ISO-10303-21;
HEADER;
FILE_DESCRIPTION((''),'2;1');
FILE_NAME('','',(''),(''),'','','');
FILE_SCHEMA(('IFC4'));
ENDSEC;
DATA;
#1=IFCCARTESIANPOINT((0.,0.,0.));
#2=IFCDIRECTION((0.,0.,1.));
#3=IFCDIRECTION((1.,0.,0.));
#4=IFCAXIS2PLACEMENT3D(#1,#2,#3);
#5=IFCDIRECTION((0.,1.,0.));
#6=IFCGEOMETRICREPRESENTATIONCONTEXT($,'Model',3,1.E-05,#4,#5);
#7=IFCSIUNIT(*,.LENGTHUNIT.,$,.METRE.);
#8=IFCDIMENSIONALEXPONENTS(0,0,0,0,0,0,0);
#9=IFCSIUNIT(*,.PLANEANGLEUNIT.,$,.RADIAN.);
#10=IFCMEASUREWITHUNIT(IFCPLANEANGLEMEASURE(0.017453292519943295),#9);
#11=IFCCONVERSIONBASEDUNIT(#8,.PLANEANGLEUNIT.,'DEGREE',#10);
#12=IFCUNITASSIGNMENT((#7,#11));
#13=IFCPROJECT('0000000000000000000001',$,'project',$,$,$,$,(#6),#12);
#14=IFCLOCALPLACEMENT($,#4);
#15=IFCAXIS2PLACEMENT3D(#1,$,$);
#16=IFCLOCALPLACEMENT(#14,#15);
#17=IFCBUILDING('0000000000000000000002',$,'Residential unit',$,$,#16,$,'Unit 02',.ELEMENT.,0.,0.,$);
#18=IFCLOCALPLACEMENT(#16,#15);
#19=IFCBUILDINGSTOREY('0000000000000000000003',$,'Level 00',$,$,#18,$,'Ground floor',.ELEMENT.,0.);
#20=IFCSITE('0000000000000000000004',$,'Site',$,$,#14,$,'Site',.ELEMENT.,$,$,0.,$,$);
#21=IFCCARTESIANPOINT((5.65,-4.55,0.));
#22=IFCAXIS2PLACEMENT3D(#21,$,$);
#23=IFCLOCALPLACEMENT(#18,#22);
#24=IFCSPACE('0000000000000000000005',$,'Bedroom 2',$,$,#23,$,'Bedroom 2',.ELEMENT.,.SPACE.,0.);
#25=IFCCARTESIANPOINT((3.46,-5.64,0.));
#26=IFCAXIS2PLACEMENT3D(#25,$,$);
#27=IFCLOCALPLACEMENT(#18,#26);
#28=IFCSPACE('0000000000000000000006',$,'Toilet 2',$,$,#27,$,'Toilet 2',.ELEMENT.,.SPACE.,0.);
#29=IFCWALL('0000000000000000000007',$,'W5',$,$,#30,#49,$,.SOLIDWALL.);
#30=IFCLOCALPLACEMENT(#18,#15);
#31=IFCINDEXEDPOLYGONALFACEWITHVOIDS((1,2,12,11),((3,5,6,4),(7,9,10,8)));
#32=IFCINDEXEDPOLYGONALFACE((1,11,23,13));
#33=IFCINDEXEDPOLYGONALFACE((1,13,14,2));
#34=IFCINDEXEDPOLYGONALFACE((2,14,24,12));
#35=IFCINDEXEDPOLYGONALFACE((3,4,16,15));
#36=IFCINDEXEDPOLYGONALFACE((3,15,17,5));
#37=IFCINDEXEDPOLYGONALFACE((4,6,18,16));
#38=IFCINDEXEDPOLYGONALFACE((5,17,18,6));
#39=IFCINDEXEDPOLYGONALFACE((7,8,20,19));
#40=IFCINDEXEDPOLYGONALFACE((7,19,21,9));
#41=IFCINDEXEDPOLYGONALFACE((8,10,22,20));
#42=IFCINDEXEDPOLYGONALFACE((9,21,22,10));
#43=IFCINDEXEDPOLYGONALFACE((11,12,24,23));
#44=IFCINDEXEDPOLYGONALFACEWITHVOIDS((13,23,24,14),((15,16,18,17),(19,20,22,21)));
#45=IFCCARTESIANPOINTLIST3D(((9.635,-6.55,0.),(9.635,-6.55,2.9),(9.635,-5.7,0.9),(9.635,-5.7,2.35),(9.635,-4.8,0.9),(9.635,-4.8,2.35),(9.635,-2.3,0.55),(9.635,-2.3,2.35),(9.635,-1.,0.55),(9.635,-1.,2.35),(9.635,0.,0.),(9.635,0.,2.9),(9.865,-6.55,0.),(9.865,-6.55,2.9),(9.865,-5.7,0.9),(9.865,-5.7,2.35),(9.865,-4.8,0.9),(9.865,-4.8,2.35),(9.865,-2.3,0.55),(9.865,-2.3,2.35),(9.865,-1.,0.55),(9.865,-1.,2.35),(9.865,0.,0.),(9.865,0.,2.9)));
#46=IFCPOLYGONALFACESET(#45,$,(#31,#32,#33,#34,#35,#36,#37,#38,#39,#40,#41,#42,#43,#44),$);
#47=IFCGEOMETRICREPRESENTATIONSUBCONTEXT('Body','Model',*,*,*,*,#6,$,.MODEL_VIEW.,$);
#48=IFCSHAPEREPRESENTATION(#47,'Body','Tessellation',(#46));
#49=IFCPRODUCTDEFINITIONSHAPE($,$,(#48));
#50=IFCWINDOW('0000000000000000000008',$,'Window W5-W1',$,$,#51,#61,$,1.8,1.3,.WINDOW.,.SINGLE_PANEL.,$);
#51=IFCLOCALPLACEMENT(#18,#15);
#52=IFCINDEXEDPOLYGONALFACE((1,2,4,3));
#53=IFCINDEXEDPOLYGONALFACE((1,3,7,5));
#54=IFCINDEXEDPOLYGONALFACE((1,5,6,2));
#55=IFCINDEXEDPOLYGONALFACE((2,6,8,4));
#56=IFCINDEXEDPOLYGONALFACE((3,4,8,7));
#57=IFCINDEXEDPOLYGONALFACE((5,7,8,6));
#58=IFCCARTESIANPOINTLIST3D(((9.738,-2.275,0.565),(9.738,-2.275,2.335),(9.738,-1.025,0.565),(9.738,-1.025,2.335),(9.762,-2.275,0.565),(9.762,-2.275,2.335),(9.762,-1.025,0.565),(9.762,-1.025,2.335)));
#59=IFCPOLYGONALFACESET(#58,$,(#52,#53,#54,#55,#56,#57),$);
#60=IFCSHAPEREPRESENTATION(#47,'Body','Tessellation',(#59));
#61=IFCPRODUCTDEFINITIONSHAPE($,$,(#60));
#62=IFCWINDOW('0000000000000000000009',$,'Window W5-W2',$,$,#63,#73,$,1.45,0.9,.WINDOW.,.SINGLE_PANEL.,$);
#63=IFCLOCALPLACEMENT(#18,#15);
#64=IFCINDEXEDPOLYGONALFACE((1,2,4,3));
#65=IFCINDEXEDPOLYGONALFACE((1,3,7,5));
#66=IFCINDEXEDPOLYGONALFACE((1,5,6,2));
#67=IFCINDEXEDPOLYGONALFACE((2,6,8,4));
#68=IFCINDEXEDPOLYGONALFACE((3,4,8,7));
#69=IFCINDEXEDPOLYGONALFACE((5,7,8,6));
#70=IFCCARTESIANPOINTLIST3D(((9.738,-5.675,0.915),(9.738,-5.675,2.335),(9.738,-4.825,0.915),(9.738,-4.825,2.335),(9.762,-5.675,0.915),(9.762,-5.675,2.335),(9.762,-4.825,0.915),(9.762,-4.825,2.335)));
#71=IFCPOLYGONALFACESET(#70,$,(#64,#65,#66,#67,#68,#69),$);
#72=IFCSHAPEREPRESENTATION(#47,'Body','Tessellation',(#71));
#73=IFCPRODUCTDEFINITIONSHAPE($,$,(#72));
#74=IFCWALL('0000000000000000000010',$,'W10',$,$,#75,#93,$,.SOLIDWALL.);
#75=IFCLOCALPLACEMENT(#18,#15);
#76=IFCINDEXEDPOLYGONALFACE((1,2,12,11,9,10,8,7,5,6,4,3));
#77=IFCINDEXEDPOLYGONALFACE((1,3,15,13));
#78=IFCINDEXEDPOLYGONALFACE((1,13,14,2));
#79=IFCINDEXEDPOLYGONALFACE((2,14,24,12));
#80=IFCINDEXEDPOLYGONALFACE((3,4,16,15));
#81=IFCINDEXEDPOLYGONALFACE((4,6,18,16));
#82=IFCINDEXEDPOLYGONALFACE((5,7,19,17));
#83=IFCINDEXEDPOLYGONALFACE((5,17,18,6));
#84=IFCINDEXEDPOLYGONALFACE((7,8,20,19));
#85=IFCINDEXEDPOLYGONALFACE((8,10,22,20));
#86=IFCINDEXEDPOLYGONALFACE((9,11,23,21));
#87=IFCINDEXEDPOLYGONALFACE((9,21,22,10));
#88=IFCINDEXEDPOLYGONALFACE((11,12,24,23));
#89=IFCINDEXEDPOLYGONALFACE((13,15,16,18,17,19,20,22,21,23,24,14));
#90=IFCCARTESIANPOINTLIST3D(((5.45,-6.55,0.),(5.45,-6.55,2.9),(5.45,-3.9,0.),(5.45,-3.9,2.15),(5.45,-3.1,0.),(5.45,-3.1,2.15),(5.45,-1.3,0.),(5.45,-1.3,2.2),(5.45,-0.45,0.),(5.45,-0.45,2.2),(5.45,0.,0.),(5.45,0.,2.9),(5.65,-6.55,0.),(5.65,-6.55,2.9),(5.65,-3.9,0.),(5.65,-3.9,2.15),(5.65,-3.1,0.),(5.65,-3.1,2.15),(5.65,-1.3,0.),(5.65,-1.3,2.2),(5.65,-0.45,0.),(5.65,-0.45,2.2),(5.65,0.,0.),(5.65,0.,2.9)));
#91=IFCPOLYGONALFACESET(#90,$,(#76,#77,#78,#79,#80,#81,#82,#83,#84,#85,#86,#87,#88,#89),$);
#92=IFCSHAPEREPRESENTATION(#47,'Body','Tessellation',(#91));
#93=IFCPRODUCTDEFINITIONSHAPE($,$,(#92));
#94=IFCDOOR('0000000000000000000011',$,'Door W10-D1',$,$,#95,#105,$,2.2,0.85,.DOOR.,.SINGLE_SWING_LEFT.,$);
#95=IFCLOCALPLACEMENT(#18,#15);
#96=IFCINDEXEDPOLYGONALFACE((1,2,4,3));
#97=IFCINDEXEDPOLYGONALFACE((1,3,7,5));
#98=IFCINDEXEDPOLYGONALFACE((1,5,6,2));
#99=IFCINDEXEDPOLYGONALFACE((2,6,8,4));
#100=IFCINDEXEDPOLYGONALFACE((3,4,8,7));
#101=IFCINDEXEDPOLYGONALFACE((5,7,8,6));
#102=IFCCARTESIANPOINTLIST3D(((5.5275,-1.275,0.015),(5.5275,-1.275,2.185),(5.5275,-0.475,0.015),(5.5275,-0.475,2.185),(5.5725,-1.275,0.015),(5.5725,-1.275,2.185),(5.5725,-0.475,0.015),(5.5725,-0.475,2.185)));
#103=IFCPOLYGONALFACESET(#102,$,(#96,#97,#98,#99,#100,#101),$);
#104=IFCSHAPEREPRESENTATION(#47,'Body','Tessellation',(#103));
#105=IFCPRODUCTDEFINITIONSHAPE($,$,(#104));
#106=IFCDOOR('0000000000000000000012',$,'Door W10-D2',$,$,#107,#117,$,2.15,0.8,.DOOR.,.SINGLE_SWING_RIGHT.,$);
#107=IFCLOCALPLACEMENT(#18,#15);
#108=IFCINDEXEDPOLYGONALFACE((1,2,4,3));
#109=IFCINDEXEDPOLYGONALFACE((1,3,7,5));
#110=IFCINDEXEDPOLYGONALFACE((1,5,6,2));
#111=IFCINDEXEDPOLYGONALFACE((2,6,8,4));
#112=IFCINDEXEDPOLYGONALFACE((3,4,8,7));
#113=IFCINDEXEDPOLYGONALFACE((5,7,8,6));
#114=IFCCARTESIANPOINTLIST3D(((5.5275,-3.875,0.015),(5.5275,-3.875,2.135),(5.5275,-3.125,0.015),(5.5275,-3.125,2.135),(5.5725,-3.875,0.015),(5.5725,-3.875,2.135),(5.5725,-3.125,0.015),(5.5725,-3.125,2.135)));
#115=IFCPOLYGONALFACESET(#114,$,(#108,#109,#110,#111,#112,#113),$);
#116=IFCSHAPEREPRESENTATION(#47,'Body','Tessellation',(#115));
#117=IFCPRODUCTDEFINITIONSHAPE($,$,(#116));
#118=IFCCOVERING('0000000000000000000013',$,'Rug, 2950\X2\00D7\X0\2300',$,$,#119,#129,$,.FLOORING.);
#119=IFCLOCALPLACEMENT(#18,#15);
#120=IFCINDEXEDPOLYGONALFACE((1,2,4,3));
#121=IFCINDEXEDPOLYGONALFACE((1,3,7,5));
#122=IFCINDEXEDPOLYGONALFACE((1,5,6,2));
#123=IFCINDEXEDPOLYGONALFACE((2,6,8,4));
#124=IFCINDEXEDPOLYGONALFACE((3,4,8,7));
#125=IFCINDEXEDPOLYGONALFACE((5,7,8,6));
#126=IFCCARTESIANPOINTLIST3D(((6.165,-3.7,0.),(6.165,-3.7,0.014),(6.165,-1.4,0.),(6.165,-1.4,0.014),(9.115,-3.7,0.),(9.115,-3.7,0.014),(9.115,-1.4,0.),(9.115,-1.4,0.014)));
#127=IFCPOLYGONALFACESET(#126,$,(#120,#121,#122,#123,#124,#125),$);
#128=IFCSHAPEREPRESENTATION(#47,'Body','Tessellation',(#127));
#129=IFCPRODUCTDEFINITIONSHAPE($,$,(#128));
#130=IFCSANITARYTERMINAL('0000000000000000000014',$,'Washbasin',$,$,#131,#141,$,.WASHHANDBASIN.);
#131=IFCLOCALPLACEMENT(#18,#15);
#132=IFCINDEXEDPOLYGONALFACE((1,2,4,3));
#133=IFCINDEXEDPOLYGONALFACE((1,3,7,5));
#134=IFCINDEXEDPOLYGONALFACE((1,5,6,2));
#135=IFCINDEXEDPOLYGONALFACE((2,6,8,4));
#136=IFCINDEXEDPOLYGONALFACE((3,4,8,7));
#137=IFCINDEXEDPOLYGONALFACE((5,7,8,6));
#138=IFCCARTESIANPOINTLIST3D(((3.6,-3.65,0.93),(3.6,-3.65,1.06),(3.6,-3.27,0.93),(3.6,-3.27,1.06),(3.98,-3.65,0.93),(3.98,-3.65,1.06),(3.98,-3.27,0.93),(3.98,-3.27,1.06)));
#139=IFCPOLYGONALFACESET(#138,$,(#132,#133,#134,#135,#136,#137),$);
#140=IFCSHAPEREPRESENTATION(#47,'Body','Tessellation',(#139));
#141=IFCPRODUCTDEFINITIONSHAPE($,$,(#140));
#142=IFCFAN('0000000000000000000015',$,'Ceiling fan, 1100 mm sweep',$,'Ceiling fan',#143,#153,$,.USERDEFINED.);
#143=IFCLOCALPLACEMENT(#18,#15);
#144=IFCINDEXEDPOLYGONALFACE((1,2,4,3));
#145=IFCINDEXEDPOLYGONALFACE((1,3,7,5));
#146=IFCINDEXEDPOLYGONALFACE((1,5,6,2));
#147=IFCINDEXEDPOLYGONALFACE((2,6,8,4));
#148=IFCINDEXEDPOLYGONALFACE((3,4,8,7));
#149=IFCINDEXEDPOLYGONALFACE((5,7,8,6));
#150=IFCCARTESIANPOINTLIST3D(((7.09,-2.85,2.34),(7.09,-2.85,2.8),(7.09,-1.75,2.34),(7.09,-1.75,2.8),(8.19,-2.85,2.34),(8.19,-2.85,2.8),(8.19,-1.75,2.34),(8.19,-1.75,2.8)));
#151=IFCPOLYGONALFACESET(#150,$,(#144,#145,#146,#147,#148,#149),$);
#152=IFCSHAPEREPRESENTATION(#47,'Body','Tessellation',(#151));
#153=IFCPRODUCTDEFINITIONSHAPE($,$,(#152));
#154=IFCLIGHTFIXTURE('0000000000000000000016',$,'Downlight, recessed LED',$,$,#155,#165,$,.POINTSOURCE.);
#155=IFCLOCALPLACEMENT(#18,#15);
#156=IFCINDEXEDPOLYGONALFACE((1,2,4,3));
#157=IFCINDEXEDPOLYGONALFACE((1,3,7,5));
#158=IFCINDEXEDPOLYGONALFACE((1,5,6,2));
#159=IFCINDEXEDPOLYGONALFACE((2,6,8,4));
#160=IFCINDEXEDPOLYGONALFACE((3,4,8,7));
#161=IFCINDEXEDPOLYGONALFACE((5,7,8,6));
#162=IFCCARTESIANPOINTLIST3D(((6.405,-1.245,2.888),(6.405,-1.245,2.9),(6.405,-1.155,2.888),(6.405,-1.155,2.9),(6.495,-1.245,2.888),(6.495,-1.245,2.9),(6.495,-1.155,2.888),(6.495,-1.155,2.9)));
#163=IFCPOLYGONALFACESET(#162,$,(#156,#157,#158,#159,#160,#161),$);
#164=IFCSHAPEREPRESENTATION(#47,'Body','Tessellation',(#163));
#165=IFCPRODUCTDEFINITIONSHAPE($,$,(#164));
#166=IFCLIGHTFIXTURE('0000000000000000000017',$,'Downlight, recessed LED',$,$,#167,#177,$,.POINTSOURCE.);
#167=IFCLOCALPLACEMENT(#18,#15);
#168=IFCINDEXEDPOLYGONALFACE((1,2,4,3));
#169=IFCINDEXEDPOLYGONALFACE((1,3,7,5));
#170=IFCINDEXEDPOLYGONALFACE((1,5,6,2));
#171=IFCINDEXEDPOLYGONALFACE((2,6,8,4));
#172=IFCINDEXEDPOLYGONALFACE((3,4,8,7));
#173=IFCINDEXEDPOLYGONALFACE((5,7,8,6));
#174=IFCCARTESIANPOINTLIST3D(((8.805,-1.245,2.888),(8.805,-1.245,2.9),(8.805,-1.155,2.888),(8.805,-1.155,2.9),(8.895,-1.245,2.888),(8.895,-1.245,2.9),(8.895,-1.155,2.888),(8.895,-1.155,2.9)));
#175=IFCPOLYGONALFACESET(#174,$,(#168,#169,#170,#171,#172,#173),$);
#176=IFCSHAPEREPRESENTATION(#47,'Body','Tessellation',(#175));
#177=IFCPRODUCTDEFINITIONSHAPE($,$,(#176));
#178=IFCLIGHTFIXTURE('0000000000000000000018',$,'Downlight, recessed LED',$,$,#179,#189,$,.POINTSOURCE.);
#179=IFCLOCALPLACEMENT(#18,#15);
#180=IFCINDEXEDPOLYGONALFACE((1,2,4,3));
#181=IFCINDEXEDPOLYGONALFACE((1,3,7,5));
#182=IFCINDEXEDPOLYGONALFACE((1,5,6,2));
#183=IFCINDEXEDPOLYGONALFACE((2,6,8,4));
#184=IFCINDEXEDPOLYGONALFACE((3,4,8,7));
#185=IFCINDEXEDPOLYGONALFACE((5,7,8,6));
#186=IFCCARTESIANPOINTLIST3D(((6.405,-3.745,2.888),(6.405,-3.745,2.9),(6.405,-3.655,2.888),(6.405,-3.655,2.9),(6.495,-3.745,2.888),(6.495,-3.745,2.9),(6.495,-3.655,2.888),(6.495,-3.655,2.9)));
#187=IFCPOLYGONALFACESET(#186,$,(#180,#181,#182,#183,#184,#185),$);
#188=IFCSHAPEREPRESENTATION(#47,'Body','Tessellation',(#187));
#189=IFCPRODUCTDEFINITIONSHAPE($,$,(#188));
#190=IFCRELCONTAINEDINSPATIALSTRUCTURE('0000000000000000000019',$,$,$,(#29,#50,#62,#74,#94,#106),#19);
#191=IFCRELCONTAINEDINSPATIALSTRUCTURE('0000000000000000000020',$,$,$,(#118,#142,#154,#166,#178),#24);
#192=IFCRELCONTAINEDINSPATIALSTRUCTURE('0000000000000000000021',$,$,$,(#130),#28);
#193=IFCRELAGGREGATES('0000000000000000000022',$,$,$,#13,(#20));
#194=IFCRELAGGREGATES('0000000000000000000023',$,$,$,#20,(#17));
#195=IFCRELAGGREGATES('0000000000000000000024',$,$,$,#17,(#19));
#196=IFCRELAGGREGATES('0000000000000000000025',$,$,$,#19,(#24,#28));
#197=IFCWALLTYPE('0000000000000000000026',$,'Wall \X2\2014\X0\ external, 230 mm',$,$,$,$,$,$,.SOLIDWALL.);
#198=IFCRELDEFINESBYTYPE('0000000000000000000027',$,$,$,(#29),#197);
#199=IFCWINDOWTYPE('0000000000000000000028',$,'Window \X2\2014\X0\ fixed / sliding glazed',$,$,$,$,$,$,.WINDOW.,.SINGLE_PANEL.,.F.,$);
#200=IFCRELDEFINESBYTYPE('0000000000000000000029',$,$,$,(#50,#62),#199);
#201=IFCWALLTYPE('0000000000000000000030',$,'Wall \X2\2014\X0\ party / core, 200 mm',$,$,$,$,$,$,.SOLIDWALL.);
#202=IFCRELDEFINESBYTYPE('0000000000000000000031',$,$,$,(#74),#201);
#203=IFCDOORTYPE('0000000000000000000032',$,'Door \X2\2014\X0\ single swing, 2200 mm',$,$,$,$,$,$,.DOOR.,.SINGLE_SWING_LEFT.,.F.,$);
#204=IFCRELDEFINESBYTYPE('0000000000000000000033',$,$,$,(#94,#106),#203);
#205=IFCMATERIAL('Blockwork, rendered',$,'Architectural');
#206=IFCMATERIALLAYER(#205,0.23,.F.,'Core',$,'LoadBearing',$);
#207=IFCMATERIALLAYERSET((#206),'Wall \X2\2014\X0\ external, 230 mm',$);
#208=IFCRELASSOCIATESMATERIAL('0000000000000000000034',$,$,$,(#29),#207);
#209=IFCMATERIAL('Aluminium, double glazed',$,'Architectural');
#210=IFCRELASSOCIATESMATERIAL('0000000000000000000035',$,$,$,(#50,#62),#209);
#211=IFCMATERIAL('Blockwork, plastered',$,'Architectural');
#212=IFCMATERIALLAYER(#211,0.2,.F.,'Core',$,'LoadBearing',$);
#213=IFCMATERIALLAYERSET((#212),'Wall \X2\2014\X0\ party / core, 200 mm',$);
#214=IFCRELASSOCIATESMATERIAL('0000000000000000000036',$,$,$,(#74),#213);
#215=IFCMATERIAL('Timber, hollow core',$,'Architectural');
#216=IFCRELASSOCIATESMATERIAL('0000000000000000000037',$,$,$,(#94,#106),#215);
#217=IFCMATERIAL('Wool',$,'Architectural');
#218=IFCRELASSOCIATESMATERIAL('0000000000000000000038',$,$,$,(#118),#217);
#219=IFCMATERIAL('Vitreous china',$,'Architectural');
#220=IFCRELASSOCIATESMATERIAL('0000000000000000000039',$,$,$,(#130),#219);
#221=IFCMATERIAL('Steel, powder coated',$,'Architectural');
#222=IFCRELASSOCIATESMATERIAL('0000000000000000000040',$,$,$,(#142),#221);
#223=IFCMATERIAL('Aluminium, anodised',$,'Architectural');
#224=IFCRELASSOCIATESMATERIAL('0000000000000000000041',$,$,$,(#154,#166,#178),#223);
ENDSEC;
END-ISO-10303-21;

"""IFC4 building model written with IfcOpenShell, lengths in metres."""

from ifc_helpers import new_model, entity, si_unit, converted_unit, direction, frame, frame_2d, origin, origin_with_axes, origin_2d, place, context, subcontext, project, spatial, rectangle, extrude, material, layer, layer_set, layer_usage, type_object, element, fill, save


model = new_model("IFC4")

# Units and contexts
model_context = context("Model", 3, precision=1e-05, world=origin_with_axes(), true_north=direction((0.0, 1.0, 0.0)))
body_context = subcontext(model_context, "Body", "Model", "MODEL_VIEW")
ifc_project = project(units=[si_unit("LENGTHUNIT", "METRE"), converted_unit("PLANEANGLEUNIT", "DEGREE", entity("IfcPlaneAngleMeasure", 0.017453292519943295), si_unit("PLANEANGLEUNIT", "RADIAN"), dimensions=[0, 0, 0, 0, 0, 0, 0])], contexts=[model_context])

# Site, building, storey
site_placement = place(None, origin_with_axes())
site = spatial("IfcSite", under=ifc_project, at=site_placement, Name="Site", LongName="Site", CompositionType="ELEMENT", RefElevation=0.0)
building_placement = place(site_placement, origin())
building = spatial("IfcBuilding", under=site, at=building_placement, Name="Residential unit", LongName="Unit 02", CompositionType="ELEMENT", ElevationOfRefHeight=0.0, ElevationOfTerrain=0.0)
storey_placement = place(building_placement, origin())
storey = spatial("IfcBuildingStorey", under=building, at=storey_placement, Name="Level 00", LongName="Ground floor", CompositionType="ELEMENT", Elevation=0.0)

# Wall, openings, windows
ifc_material_1 = material(Name="Blockwork, rendered", Category="Architectural")
ifc_layer_1 = layer(ifc_material_1, 0.23, ventilated=False, Name="Core", Category="LoadBearing")
ifc_layer_set_1 = layer_set([ifc_layer_1], Name="Wall — external, 230 mm")
ifc_layer_usage_1 = layer_usage(ifc_layer_set_1, "AXIS2", "POSITIVE", -0.115)
wall_type_1 = type_object("IfcWallType", Name="Wall — external, 230 mm", PredefinedType="SOLIDWALL")
wall_1_placement = place(storey_placement, frame((9.75, 0.0, 0.0), z_axis=(0.0, 0.0, 1.0), x_axis=(0.0, -1.0, 0.0)))
wall_1 = element("IfcWall", 1, at=wall_1_placement, inside=storey, type_object=wall_type_1, material=ifc_layer_usage_1, Name="W5", PredefinedType="SOLIDWALL", context=body_context, shape_type="SweptSolid", body=[
    extrude(rectangle(XDim=6.55, YDim=0.23, at=frame_2d((3.275, 0.0))), origin(), (0.0, 0.0, 1.0), 2.9),
])
opening_1_placement = place(wall_1_placement, frame((1.65, 0.0, 0.55)))
opening_1 = element("IfcOpeningElement", 2, at=opening_1_placement, cuts=wall_1, PredefinedType="OPENING", context=body_context, shape_type="SweptSolid", body=[
    extrude(rectangle(XDim=1.3, YDim=0.29, at=origin_2d()), origin(), (0.0, 0.0, 1.0), 1.8),
])
opening_2_placement = place(wall_1_placement, frame((5.25, 0.0, 0.9)))
opening_2 = element("IfcOpeningElement", 3, at=opening_2_placement, cuts=wall_1, PredefinedType="OPENING", context=body_context, shape_type="SweptSolid", body=[
    extrude(rectangle(XDim=0.9, YDim=0.29, at=origin_2d()), origin(), (0.0, 0.0, 1.0), 1.45),
])
ifc_material_2 = material(Name="Aluminium, double glazed", Category="Architectural")
window_type = type_object("IfcWindowType", Name="Window — fixed / sliding glazed", ParameterTakesPrecedence=False, PartitioningType="SINGLE_PANEL", PredefinedType="WINDOW")
window_1_placement = place(wall_1_placement, frame((1.65, 0.0, 0.55)))
window_1 = element("IfcWindow", 4, at=window_1_placement, inside=storey, type_object=window_type, material=ifc_material_2, Name="Window W5-W1", OverallHeight=1.8, OverallWidth=1.3, PartitioningType="SINGLE_PANEL", PredefinedType="WINDOW", context=body_context, shape_type="SweptSolid", body=[
    extrude(rectangle(XDim=1.25, YDim=0.024, at=origin_2d()), frame((0.0, 0.0, 0.015)), (0.0, 0.0, 1.0), 1.77),
])
fill(opening_1, window_1)
window_2_placement = place(wall_1_placement, frame((5.25, 0.0, 0.9)))
window_2 = element("IfcWindow", 5, at=window_2_placement, inside=storey, type_object=window_type, material=ifc_material_2, Name="Window W5-W2", OverallHeight=1.45, OverallWidth=0.9, PartitioningType="SINGLE_PANEL", PredefinedType="WINDOW", context=body_context, shape_type="SweptSolid", body=[
    extrude(rectangle(XDim=0.85, YDim=0.024, at=origin_2d()), frame((0.0, 0.0, 0.015)), (0.0, 0.0, 1.0), 1.42),
])
fill(opening_2, window_2)

# Wall, openings, doors
ifc_material_3 = material(Name="Blockwork, plastered", Category="Architectural")
ifc_layer_2 = layer(ifc_material_3, 0.2, ventilated=False, Name="Core", Category="LoadBearing")
ifc_layer_set_2 = layer_set([ifc_layer_2], Name="Wall — party / core, 200 mm")
ifc_layer_usage_2 = layer_usage(ifc_layer_set_2, "AXIS2", "POSITIVE", -0.1)
wall_type_2 = type_object("IfcWallType", Name="Wall — party / core, 200 mm", PredefinedType="SOLIDWALL")
wall_2_placement = place(storey_placement, frame((5.55, 0.0, 0.0), z_axis=(0.0, 0.0, 1.0), x_axis=(0.0, -1.0, 0.0)))
wall_2 = element("IfcWall", 6, at=wall_2_placement, inside=storey, type_object=wall_type_2, material=ifc_layer_usage_2, Name="W10", PredefinedType="SOLIDWALL", context=body_context, shape_type="SweptSolid", body=[
    extrude(rectangle(XDim=6.55, YDim=0.2, at=frame_2d((3.275, 0.0))), origin(), (0.0, 0.0, 1.0), 2.9),
])
opening_3_placement = place(wall_2_placement, frame((0.875, 0.0, 0.0)))
opening_3 = element("IfcOpeningElement", 7, at=opening_3_placement, cuts=wall_2, PredefinedType="OPENING", context=body_context, shape_type="SweptSolid", body=[
    extrude(rectangle(XDim=0.85, YDim=0.26, at=origin_2d()), origin(), (0.0, 0.0, 1.0), 2.2),
])
opening_4_placement = place(wall_2_placement, frame((3.5, 0.0, 0.0)))
opening_4 = element("IfcOpeningElement", 8, at=opening_4_placement, cuts=wall_2, PredefinedType="OPENING", context=body_context, shape_type="SweptSolid", body=[
    extrude(rectangle(XDim=0.8, YDim=0.26, at=origin_2d()), origin(), (0.0, 0.0, 1.0), 2.15),
])
ifc_material_4 = material(Name="Timber, hollow core", Category="Architectural")
door_type = type_object("IfcDoorType", Name="Door — single swing, 2200 mm", OperationType="SINGLE_SWING_LEFT", ParameterTakesPrecedence=False, PredefinedType="DOOR")
door_1_placement = place(wall_2_placement, frame((0.875, 0.0, 0.0)))
door_1 = element("IfcDoor", 9, at=door_1_placement, inside=storey, type_object=door_type, material=ifc_material_4, Name="Door W10-D1", OperationType="SINGLE_SWING_LEFT", OverallHeight=2.2, OverallWidth=0.85, PredefinedType="DOOR", context=body_context, shape_type="SweptSolid", body=[
    extrude(rectangle(XDim=0.8, YDim=0.045, at=origin_2d()), frame((0.0, 0.0, 0.015)), (0.0, 0.0, 1.0), 2.17),
])
fill(opening_3, door_1)
door_2_placement = place(wall_2_placement, frame((3.5, 0.0, 0.0)))
door_2 = element("IfcDoor", 10, at=door_2_placement, inside=storey, type_object=door_type, material=ifc_material_4, Name="Door W10-D2", OperationType="SINGLE_SWING_RIGHT", OverallHeight=2.15, OverallWidth=0.8, PredefinedType="DOOR", context=body_context, shape_type="SweptSolid", body=[
    extrude(rectangle(XDim=0.75, YDim=0.045, at=origin_2d()), frame((0.0, 0.0, 0.015)), (0.0, 0.0, 1.0), 2.12),
])
fill(opening_4, door_2)

# Shared definitions
space_1_placement = place(storey_placement, frame((5.65, -4.55, 0.0)))
space_1 = spatial("IfcSpace", under=storey, at=space_1_placement, Name="Bedroom 2", LongName="Bedroom 2", CompositionType="ELEMENT", PredefinedType="SPACE", ElevationWithFlooring=0.0)

# Covering
ifc_material_5 = material(Name="Wool", Category="Architectural")
covering_placement = place(storey_placement, frame((6.165, -3.7, 0.0)))
element("IfcCovering", 11, at=covering_placement, inside=space_1, material=ifc_material_5, Name="Rug, 2950×2300", PredefinedType="FLOORING", context=body_context, shape_type="SweptSolid", body=[
    extrude(rectangle(XDim=2.95, YDim=2.3, at=frame_2d((1.475, 1.15))), origin(), (0.0, 0.0, 1.0), 0.014),
])

# Shared definitions
space_2_placement = place(storey_placement, frame((3.46, -5.64, 0.0)))
space_2 = spatial("IfcSpace", under=storey, at=space_2_placement, Name="Toilet 2", LongName="Toilet 2", CompositionType="ELEMENT", PredefinedType="SPACE", ElevationWithFlooring=0.0)

# Sanitary terminal
ifc_material_6 = material(Name="Vitreous china", Category="Architectural")
sanitary_terminal_placement = place(storey_placement, frame((3.6, -3.65, 0.93)))
element("IfcSanitaryTerminal", 12, at=sanitary_terminal_placement, inside=space_2, material=ifc_material_6, Name="Washbasin", PredefinedType="WASHHANDBASIN", context=body_context, shape_type="SweptSolid", body=[
    extrude(rectangle(XDim=0.38, YDim=0.38, at=frame_2d((0.19, 0.19))), origin(), (0.0, 0.0, 1.0), 0.13),
])

# Fan
ifc_material_7 = material(Name="Steel, powder coated", Category="Architectural")
fan_placement = place(storey_placement, frame((7.09, -2.85, 2.34)))
element("IfcFan", 13, at=fan_placement, inside=space_1, material=ifc_material_7, Name="Ceiling fan, 1100 mm sweep", ObjectType="Ceiling fan", PredefinedType="USERDEFINED", context=body_context, shape_type="SweptSolid", body=[
    extrude(rectangle(XDim=1.1, YDim=1.1, at=frame_2d((0.55, 0.55))), origin(), (0.0, 0.0, 1.0), 0.46),
])

# Light fixtures
ifc_material_8 = material(Name="Aluminium, anodised", Category="Architectural")
for number, where, name in (
    (14, (6.405, -1.245, 2.888), "Downlight, recessed LED"),
    (15, (8.805, -1.245, 2.888), "Downlight, recessed LED"),
    (16, (6.405, -3.745, 2.888), "Downlight, recessed LED"),
):
    element("IfcLightFixture", number, at=place(storey_placement, frame(where)), inside=space_1, material=ifc_material_8, Name=name, PredefinedType="POINTSOURCE", context=body_context, shape_type="SweptSolid", body=[
        extrude(rectangle(XDim=0.09, YDim=0.09, at=frame_2d((0.045, 0.045))), origin(), (0.0, 0.0, 1.0), 0.012),
    ])

save(model, "model.ifc")
